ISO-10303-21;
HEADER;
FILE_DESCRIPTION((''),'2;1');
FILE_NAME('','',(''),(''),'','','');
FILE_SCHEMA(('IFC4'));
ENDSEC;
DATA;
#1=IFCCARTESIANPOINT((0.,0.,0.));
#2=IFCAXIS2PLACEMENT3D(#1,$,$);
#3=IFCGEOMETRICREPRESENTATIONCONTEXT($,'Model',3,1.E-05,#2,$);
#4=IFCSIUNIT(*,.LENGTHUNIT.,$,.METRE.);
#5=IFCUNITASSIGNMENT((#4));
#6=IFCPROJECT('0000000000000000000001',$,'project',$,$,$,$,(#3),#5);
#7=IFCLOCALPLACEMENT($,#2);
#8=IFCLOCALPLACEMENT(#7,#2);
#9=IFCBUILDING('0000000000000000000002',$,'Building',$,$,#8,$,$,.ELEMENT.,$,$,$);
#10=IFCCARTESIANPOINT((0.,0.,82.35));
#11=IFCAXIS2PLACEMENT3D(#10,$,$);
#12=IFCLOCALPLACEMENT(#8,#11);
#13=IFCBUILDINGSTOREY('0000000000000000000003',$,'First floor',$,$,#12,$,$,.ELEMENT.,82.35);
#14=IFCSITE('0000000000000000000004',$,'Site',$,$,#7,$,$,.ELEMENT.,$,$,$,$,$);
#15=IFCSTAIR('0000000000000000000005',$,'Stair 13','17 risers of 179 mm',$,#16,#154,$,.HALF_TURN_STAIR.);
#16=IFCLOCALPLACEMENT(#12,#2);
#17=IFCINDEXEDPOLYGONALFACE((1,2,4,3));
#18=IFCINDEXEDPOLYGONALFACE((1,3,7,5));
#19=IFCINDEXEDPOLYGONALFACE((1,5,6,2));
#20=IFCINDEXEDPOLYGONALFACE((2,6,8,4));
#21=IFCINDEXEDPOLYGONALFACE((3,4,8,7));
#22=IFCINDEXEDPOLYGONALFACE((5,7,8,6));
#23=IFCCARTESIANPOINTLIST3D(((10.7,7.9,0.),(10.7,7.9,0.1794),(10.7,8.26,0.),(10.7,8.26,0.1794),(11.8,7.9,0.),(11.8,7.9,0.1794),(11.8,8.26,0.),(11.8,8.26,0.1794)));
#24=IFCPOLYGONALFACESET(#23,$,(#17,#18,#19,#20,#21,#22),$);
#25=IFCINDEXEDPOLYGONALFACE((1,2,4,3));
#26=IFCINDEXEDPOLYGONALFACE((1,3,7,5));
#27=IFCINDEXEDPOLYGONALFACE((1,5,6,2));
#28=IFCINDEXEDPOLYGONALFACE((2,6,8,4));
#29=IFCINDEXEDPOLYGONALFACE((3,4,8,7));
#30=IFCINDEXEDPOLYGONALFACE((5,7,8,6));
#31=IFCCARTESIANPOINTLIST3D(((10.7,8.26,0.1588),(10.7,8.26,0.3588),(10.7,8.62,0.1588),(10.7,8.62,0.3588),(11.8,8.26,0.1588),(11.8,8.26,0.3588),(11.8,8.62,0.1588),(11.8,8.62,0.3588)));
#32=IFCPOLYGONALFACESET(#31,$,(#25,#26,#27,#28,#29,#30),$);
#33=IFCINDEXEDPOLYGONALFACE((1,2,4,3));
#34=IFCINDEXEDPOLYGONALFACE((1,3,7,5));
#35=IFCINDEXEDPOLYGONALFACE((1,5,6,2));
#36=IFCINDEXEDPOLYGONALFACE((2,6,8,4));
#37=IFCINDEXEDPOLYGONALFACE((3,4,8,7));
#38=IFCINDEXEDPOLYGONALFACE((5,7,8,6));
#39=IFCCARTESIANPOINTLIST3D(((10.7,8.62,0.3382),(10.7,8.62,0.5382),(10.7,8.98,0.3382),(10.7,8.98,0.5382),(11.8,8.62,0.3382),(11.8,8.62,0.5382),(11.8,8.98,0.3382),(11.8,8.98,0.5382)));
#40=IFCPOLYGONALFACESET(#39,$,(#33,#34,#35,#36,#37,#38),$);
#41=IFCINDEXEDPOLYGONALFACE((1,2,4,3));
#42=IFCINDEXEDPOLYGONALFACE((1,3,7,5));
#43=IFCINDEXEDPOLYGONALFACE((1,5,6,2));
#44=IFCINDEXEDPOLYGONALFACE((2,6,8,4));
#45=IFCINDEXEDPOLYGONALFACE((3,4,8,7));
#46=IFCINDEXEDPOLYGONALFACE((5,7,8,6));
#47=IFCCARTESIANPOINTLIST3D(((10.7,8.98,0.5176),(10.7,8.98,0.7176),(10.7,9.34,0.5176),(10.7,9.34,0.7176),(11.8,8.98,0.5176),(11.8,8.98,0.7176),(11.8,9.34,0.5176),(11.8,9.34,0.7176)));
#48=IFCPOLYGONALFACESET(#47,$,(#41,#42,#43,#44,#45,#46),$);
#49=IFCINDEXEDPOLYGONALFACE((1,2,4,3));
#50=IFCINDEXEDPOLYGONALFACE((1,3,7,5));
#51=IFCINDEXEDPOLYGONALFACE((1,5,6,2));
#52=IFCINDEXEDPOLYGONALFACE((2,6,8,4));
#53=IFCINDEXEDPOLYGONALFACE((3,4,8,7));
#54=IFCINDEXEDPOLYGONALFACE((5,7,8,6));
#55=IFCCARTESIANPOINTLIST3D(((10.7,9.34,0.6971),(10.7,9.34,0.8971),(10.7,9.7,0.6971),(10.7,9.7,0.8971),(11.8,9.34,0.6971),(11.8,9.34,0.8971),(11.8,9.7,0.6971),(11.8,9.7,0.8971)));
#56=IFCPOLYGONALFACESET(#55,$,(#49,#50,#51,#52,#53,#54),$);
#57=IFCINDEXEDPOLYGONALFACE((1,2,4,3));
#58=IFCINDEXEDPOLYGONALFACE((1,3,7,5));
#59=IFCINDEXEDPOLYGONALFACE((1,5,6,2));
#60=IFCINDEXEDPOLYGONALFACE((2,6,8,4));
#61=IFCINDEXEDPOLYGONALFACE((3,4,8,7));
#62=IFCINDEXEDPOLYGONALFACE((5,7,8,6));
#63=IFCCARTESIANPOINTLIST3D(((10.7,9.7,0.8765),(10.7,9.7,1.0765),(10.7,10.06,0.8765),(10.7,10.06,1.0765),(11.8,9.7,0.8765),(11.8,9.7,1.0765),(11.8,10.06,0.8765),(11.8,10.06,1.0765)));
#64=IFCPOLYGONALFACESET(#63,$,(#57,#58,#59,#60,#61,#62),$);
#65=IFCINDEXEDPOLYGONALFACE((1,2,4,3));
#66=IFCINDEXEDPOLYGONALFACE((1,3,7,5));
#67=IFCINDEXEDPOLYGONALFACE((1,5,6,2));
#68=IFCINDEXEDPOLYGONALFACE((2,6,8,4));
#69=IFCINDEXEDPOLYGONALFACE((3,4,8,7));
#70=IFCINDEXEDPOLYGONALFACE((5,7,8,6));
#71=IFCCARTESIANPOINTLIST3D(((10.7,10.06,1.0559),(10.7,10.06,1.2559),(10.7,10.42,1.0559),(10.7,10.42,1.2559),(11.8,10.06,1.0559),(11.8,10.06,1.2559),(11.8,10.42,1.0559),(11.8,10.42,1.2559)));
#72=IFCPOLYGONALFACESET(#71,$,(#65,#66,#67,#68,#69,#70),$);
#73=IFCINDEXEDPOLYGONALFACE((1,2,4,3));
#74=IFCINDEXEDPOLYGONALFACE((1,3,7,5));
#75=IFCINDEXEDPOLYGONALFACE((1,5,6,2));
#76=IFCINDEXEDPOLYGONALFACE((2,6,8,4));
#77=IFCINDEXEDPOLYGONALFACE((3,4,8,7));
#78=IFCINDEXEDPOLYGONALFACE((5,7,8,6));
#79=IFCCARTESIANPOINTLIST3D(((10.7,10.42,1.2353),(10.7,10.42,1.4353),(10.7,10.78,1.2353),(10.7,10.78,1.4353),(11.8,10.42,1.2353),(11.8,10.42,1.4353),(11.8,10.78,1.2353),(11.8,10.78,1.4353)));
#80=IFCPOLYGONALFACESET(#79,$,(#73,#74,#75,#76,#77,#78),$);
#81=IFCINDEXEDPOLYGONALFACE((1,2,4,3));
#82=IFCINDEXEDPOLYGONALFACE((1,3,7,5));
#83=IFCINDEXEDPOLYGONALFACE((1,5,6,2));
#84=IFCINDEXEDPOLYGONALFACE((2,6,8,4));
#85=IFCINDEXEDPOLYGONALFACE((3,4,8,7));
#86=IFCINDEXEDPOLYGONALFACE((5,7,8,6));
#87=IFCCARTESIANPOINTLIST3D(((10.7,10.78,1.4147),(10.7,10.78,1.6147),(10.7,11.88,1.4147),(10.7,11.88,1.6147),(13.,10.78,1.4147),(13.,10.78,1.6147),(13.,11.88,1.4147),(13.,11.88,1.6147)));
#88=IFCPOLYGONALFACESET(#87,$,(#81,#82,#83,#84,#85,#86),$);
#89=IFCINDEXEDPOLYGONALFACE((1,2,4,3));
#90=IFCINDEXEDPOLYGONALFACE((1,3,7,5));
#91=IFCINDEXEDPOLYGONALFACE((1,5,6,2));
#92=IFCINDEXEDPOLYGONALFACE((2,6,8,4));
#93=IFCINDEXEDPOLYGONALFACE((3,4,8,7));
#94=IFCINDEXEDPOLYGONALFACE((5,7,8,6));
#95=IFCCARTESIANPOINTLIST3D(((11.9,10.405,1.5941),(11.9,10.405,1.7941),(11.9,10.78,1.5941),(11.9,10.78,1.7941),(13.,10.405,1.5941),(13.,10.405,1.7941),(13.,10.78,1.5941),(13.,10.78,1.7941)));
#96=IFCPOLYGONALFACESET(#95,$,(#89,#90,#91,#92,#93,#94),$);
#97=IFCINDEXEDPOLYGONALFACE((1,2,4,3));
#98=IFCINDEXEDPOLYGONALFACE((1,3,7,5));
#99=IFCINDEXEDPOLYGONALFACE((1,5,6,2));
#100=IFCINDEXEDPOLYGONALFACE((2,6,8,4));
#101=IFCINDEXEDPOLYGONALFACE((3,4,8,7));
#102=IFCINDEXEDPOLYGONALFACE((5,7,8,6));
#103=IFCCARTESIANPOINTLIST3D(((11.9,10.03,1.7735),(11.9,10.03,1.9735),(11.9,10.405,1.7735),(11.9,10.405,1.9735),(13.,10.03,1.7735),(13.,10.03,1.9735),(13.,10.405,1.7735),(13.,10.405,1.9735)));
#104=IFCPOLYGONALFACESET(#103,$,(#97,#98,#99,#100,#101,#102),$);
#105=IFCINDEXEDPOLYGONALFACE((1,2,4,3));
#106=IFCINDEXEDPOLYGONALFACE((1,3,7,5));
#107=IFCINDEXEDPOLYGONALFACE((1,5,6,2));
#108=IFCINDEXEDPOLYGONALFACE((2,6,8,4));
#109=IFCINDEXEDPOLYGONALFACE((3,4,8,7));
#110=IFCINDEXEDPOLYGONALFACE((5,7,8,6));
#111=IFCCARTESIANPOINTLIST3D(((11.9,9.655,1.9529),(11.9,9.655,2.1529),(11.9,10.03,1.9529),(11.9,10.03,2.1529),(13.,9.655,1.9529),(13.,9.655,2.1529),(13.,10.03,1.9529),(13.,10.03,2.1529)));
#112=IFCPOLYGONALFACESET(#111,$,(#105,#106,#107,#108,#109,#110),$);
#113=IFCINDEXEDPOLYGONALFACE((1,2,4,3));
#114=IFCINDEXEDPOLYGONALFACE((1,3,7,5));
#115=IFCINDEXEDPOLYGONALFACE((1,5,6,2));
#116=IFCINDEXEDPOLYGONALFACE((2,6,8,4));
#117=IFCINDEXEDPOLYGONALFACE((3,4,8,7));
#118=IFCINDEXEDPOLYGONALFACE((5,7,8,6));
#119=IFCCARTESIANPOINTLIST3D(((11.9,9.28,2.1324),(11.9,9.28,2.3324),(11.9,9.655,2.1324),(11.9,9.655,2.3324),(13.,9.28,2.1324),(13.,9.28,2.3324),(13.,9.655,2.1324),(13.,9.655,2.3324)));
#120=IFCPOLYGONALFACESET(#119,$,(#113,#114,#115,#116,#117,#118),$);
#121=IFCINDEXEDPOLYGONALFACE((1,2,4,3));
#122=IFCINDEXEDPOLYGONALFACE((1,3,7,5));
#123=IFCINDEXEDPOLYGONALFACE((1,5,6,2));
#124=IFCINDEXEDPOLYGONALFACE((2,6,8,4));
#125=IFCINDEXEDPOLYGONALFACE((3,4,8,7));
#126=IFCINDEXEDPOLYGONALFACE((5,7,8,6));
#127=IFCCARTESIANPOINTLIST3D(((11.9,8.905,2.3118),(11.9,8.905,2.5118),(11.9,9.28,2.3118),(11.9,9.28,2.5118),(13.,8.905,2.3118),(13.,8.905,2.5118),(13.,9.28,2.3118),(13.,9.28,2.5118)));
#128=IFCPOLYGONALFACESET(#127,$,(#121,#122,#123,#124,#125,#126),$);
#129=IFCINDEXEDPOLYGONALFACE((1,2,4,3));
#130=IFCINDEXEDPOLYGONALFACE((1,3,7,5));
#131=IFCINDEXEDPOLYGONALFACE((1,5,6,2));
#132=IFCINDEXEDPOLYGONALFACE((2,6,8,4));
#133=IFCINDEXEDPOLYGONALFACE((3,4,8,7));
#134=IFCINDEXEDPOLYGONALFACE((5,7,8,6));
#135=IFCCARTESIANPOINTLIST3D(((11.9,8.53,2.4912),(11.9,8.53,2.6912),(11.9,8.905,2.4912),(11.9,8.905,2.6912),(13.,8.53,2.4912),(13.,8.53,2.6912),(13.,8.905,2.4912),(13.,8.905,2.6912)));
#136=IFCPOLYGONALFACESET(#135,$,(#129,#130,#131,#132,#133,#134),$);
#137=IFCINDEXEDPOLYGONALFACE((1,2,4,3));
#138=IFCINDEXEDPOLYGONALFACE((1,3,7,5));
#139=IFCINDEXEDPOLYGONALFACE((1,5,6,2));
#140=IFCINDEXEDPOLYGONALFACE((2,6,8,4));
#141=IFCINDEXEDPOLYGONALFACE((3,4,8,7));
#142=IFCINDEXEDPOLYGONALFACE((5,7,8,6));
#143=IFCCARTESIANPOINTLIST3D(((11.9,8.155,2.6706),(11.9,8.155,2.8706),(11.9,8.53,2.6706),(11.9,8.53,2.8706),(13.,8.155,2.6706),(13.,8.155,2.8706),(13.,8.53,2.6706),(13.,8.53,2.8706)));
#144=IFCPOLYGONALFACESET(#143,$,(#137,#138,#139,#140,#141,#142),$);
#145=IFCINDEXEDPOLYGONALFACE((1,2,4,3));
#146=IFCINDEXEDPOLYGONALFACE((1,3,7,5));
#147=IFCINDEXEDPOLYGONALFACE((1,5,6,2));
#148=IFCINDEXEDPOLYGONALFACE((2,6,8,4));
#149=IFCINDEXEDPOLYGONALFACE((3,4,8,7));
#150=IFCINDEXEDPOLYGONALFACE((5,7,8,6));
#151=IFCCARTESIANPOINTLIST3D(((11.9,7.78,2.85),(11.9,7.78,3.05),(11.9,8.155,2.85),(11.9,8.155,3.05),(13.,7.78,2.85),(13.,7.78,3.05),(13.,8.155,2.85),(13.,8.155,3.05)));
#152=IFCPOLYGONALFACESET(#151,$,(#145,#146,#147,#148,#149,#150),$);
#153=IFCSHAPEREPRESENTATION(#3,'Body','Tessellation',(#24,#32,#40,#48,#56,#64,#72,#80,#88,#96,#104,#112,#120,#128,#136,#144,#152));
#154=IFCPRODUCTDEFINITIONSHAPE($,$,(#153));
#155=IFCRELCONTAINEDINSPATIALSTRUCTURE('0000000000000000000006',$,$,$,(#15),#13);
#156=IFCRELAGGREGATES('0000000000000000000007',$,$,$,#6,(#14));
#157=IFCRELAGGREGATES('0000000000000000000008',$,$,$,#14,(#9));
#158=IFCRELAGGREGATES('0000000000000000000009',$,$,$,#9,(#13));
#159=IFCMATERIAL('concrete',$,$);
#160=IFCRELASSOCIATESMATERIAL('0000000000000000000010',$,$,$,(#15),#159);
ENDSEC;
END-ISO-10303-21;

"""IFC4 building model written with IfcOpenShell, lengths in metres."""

from ifc_helpers import new_model, si_unit, frame, origin, place, context, project, spatial, polyline, outline, extrude, material, element, save


model = new_model("IFC4")

# Units and contexts
model_context = context("Model", 3, precision=1e-05, world=origin())
ifc_project = project(units=[si_unit("LENGTHUNIT", "METRE")], contexts=[model_context])

# Site, building, storey
site_placement = place(None, origin())
site = spatial("IfcSite", under=ifc_project, at=site_placement, Name="Site", CompositionType="ELEMENT")
building_placement = place(site_placement, origin())
building = spatial("IfcBuilding", under=site, at=building_placement, Name="Building", CompositionType="ELEMENT")
storey_placement = place(building_placement, frame((0.0, 0.0, 82.35)))
storey = spatial("IfcBuildingStorey", under=building, at=storey_placement, Name="First floor", CompositionType="ELEMENT", Elevation=82.35)

# Shared definitions
ifc_material = material(Name="concrete")

# Stair
stair_placement = place(storey_placement, frame((11.25, 7.9, 0.0), z_axis=(0.0, 0.0, 1.0), x_axis=(0.0, 1.0, 0.0)))
element("IfcStair", 1, at=stair_placement, inside=storey, material=ifc_material, Name="Stair 13", Description="17 risers of 179 mm", PredefinedType="HALF_TURN_STAIR", context=model_context, shape_type="SweptSolid", body=[
    extrude(outline(polyline([(0.0, -0.55), (0.36, -0.55), (0.36, 0.55), (0.0, 0.55), (0.0, -0.55)])), origin(), (0.0, 0.0, 1.0), 0.1794),
    extrude(outline(polyline([(0.36, -0.55), (0.72, -0.55), (0.72, 0.55), (0.36, 0.55), (0.36, -0.55)])), frame((0.0, 0.0, 0.1588)), (0.0, 0.0, 1.0), 0.2),
    extrude(outline(polyline([(0.72, -0.55), (1.08, -0.55), (1.08, 0.55), (0.72, 0.55), (0.72, -0.55)])), frame((0.0, 0.0, 0.3382)), (0.0, 0.0, 1.0), 0.2),
    extrude(outline(polyline([(1.08, -0.55), (1.44, -0.55), (1.44, 0.55), (1.08, 0.55), (1.08, -0.55)])), frame((0.0, 0.0, 0.5176)), (0.0, 0.0, 1.0), 0.2),
    extrude(outline(polyline([(1.44, -0.55), (1.8, -0.55), (1.8, 0.55), (1.44, 0.55), (1.44, -0.55)])), frame((0.0, 0.0, 0.6971)), (0.0, 0.0, 1.0), 0.2),
    extrude(outline(polyline([(1.8, -0.55), (2.16, -0.55), (2.16, 0.55), (1.8, 0.55), (1.8, -0.55)])), frame((0.0, 0.0, 0.8765)), (0.0, 0.0, 1.0), 0.2),
    extrude(outline(polyline([(2.16, -0.55), (2.52, -0.55), (2.52, 0.55), (2.16, 0.55), (2.16, -0.55)])), frame((0.0, 0.0, 1.0559)), (0.0, 0.0, 1.0), 0.2),
    extrude(outline(polyline([(2.52, -0.55), (2.88, -0.55), (2.88, 0.55), (2.52, 0.55), (2.52, -0.55)])), frame((0.0, 0.0, 1.2353)), (0.0, 0.0, 1.0), 0.2),
    extrude(outline(polyline([(2.88, -1.75), (3.98, -1.75), (3.98, 0.55), (2.88, 0.55), (2.88, -1.75)])), frame((0.0, 0.0, 1.4147)), (0.0, 0.0, 1.0), 0.2),
    extrude(outline(polyline([(2.505, -1.75), (2.88, -1.75), (2.88, -0.65), (2.505, -0.65), (2.505, -1.75)])), frame((0.0, 0.0, 1.5941)), (0.0, 0.0, 1.0), 0.2),
    extrude(outline(polyline([(2.13, -1.75), (2.505, -1.75), (2.505, -0.65), (2.13, -0.65), (2.13, -1.75)])), frame((0.0, 0.0, 1.7735)), (0.0, 0.0, 1.0), 0.2),
    extrude(outline(polyline([(1.755, -1.75), (2.13, -1.75), (2.13, -0.65), (1.755, -0.65), (1.755, -1.75)])), frame((0.0, 0.0, 1.9529)), (0.0, 0.0, 1.0), 0.2),
    extrude(outline(polyline([(1.38, -1.75), (1.755, -1.75), (1.755, -0.65), (1.38, -0.65), (1.38, -1.75)])), frame((0.0, 0.0, 2.1324)), (0.0, 0.0, 1.0), 0.2),
    extrude(outline(polyline([(1.005, -1.75), (1.38, -1.75), (1.38, -0.65), (1.005, -0.65), (1.005, -1.75)])), frame((0.0, 0.0, 2.3118)), (0.0, 0.0, 1.0), 0.2),
    extrude(outline(polyline([(0.63, -1.75), (1.005, -1.75), (1.005, -0.65), (0.63, -0.65), (0.63, -1.75)])), frame((0.0, 0.0, 2.4912)), (0.0, 0.0, 1.0), 0.2),
    extrude(outline(polyline([(0.255, -1.75), (0.63, -1.75), (0.63, -0.65), (0.255, -0.65), (0.255, -1.75)])), frame((0.0, 0.0, 2.6706)), (0.0, 0.0, 1.0), 0.2),
    extrude(outline(polyline([(-0.12, -1.75), (0.255, -1.75), (0.255, -0.65), (-0.12, -0.65), (-0.12, -1.75)])), frame((0.0, 0.0, 2.85)), (0.0, 0.0, 1.0), 0.2),
])

save(model, "model.ifc")
